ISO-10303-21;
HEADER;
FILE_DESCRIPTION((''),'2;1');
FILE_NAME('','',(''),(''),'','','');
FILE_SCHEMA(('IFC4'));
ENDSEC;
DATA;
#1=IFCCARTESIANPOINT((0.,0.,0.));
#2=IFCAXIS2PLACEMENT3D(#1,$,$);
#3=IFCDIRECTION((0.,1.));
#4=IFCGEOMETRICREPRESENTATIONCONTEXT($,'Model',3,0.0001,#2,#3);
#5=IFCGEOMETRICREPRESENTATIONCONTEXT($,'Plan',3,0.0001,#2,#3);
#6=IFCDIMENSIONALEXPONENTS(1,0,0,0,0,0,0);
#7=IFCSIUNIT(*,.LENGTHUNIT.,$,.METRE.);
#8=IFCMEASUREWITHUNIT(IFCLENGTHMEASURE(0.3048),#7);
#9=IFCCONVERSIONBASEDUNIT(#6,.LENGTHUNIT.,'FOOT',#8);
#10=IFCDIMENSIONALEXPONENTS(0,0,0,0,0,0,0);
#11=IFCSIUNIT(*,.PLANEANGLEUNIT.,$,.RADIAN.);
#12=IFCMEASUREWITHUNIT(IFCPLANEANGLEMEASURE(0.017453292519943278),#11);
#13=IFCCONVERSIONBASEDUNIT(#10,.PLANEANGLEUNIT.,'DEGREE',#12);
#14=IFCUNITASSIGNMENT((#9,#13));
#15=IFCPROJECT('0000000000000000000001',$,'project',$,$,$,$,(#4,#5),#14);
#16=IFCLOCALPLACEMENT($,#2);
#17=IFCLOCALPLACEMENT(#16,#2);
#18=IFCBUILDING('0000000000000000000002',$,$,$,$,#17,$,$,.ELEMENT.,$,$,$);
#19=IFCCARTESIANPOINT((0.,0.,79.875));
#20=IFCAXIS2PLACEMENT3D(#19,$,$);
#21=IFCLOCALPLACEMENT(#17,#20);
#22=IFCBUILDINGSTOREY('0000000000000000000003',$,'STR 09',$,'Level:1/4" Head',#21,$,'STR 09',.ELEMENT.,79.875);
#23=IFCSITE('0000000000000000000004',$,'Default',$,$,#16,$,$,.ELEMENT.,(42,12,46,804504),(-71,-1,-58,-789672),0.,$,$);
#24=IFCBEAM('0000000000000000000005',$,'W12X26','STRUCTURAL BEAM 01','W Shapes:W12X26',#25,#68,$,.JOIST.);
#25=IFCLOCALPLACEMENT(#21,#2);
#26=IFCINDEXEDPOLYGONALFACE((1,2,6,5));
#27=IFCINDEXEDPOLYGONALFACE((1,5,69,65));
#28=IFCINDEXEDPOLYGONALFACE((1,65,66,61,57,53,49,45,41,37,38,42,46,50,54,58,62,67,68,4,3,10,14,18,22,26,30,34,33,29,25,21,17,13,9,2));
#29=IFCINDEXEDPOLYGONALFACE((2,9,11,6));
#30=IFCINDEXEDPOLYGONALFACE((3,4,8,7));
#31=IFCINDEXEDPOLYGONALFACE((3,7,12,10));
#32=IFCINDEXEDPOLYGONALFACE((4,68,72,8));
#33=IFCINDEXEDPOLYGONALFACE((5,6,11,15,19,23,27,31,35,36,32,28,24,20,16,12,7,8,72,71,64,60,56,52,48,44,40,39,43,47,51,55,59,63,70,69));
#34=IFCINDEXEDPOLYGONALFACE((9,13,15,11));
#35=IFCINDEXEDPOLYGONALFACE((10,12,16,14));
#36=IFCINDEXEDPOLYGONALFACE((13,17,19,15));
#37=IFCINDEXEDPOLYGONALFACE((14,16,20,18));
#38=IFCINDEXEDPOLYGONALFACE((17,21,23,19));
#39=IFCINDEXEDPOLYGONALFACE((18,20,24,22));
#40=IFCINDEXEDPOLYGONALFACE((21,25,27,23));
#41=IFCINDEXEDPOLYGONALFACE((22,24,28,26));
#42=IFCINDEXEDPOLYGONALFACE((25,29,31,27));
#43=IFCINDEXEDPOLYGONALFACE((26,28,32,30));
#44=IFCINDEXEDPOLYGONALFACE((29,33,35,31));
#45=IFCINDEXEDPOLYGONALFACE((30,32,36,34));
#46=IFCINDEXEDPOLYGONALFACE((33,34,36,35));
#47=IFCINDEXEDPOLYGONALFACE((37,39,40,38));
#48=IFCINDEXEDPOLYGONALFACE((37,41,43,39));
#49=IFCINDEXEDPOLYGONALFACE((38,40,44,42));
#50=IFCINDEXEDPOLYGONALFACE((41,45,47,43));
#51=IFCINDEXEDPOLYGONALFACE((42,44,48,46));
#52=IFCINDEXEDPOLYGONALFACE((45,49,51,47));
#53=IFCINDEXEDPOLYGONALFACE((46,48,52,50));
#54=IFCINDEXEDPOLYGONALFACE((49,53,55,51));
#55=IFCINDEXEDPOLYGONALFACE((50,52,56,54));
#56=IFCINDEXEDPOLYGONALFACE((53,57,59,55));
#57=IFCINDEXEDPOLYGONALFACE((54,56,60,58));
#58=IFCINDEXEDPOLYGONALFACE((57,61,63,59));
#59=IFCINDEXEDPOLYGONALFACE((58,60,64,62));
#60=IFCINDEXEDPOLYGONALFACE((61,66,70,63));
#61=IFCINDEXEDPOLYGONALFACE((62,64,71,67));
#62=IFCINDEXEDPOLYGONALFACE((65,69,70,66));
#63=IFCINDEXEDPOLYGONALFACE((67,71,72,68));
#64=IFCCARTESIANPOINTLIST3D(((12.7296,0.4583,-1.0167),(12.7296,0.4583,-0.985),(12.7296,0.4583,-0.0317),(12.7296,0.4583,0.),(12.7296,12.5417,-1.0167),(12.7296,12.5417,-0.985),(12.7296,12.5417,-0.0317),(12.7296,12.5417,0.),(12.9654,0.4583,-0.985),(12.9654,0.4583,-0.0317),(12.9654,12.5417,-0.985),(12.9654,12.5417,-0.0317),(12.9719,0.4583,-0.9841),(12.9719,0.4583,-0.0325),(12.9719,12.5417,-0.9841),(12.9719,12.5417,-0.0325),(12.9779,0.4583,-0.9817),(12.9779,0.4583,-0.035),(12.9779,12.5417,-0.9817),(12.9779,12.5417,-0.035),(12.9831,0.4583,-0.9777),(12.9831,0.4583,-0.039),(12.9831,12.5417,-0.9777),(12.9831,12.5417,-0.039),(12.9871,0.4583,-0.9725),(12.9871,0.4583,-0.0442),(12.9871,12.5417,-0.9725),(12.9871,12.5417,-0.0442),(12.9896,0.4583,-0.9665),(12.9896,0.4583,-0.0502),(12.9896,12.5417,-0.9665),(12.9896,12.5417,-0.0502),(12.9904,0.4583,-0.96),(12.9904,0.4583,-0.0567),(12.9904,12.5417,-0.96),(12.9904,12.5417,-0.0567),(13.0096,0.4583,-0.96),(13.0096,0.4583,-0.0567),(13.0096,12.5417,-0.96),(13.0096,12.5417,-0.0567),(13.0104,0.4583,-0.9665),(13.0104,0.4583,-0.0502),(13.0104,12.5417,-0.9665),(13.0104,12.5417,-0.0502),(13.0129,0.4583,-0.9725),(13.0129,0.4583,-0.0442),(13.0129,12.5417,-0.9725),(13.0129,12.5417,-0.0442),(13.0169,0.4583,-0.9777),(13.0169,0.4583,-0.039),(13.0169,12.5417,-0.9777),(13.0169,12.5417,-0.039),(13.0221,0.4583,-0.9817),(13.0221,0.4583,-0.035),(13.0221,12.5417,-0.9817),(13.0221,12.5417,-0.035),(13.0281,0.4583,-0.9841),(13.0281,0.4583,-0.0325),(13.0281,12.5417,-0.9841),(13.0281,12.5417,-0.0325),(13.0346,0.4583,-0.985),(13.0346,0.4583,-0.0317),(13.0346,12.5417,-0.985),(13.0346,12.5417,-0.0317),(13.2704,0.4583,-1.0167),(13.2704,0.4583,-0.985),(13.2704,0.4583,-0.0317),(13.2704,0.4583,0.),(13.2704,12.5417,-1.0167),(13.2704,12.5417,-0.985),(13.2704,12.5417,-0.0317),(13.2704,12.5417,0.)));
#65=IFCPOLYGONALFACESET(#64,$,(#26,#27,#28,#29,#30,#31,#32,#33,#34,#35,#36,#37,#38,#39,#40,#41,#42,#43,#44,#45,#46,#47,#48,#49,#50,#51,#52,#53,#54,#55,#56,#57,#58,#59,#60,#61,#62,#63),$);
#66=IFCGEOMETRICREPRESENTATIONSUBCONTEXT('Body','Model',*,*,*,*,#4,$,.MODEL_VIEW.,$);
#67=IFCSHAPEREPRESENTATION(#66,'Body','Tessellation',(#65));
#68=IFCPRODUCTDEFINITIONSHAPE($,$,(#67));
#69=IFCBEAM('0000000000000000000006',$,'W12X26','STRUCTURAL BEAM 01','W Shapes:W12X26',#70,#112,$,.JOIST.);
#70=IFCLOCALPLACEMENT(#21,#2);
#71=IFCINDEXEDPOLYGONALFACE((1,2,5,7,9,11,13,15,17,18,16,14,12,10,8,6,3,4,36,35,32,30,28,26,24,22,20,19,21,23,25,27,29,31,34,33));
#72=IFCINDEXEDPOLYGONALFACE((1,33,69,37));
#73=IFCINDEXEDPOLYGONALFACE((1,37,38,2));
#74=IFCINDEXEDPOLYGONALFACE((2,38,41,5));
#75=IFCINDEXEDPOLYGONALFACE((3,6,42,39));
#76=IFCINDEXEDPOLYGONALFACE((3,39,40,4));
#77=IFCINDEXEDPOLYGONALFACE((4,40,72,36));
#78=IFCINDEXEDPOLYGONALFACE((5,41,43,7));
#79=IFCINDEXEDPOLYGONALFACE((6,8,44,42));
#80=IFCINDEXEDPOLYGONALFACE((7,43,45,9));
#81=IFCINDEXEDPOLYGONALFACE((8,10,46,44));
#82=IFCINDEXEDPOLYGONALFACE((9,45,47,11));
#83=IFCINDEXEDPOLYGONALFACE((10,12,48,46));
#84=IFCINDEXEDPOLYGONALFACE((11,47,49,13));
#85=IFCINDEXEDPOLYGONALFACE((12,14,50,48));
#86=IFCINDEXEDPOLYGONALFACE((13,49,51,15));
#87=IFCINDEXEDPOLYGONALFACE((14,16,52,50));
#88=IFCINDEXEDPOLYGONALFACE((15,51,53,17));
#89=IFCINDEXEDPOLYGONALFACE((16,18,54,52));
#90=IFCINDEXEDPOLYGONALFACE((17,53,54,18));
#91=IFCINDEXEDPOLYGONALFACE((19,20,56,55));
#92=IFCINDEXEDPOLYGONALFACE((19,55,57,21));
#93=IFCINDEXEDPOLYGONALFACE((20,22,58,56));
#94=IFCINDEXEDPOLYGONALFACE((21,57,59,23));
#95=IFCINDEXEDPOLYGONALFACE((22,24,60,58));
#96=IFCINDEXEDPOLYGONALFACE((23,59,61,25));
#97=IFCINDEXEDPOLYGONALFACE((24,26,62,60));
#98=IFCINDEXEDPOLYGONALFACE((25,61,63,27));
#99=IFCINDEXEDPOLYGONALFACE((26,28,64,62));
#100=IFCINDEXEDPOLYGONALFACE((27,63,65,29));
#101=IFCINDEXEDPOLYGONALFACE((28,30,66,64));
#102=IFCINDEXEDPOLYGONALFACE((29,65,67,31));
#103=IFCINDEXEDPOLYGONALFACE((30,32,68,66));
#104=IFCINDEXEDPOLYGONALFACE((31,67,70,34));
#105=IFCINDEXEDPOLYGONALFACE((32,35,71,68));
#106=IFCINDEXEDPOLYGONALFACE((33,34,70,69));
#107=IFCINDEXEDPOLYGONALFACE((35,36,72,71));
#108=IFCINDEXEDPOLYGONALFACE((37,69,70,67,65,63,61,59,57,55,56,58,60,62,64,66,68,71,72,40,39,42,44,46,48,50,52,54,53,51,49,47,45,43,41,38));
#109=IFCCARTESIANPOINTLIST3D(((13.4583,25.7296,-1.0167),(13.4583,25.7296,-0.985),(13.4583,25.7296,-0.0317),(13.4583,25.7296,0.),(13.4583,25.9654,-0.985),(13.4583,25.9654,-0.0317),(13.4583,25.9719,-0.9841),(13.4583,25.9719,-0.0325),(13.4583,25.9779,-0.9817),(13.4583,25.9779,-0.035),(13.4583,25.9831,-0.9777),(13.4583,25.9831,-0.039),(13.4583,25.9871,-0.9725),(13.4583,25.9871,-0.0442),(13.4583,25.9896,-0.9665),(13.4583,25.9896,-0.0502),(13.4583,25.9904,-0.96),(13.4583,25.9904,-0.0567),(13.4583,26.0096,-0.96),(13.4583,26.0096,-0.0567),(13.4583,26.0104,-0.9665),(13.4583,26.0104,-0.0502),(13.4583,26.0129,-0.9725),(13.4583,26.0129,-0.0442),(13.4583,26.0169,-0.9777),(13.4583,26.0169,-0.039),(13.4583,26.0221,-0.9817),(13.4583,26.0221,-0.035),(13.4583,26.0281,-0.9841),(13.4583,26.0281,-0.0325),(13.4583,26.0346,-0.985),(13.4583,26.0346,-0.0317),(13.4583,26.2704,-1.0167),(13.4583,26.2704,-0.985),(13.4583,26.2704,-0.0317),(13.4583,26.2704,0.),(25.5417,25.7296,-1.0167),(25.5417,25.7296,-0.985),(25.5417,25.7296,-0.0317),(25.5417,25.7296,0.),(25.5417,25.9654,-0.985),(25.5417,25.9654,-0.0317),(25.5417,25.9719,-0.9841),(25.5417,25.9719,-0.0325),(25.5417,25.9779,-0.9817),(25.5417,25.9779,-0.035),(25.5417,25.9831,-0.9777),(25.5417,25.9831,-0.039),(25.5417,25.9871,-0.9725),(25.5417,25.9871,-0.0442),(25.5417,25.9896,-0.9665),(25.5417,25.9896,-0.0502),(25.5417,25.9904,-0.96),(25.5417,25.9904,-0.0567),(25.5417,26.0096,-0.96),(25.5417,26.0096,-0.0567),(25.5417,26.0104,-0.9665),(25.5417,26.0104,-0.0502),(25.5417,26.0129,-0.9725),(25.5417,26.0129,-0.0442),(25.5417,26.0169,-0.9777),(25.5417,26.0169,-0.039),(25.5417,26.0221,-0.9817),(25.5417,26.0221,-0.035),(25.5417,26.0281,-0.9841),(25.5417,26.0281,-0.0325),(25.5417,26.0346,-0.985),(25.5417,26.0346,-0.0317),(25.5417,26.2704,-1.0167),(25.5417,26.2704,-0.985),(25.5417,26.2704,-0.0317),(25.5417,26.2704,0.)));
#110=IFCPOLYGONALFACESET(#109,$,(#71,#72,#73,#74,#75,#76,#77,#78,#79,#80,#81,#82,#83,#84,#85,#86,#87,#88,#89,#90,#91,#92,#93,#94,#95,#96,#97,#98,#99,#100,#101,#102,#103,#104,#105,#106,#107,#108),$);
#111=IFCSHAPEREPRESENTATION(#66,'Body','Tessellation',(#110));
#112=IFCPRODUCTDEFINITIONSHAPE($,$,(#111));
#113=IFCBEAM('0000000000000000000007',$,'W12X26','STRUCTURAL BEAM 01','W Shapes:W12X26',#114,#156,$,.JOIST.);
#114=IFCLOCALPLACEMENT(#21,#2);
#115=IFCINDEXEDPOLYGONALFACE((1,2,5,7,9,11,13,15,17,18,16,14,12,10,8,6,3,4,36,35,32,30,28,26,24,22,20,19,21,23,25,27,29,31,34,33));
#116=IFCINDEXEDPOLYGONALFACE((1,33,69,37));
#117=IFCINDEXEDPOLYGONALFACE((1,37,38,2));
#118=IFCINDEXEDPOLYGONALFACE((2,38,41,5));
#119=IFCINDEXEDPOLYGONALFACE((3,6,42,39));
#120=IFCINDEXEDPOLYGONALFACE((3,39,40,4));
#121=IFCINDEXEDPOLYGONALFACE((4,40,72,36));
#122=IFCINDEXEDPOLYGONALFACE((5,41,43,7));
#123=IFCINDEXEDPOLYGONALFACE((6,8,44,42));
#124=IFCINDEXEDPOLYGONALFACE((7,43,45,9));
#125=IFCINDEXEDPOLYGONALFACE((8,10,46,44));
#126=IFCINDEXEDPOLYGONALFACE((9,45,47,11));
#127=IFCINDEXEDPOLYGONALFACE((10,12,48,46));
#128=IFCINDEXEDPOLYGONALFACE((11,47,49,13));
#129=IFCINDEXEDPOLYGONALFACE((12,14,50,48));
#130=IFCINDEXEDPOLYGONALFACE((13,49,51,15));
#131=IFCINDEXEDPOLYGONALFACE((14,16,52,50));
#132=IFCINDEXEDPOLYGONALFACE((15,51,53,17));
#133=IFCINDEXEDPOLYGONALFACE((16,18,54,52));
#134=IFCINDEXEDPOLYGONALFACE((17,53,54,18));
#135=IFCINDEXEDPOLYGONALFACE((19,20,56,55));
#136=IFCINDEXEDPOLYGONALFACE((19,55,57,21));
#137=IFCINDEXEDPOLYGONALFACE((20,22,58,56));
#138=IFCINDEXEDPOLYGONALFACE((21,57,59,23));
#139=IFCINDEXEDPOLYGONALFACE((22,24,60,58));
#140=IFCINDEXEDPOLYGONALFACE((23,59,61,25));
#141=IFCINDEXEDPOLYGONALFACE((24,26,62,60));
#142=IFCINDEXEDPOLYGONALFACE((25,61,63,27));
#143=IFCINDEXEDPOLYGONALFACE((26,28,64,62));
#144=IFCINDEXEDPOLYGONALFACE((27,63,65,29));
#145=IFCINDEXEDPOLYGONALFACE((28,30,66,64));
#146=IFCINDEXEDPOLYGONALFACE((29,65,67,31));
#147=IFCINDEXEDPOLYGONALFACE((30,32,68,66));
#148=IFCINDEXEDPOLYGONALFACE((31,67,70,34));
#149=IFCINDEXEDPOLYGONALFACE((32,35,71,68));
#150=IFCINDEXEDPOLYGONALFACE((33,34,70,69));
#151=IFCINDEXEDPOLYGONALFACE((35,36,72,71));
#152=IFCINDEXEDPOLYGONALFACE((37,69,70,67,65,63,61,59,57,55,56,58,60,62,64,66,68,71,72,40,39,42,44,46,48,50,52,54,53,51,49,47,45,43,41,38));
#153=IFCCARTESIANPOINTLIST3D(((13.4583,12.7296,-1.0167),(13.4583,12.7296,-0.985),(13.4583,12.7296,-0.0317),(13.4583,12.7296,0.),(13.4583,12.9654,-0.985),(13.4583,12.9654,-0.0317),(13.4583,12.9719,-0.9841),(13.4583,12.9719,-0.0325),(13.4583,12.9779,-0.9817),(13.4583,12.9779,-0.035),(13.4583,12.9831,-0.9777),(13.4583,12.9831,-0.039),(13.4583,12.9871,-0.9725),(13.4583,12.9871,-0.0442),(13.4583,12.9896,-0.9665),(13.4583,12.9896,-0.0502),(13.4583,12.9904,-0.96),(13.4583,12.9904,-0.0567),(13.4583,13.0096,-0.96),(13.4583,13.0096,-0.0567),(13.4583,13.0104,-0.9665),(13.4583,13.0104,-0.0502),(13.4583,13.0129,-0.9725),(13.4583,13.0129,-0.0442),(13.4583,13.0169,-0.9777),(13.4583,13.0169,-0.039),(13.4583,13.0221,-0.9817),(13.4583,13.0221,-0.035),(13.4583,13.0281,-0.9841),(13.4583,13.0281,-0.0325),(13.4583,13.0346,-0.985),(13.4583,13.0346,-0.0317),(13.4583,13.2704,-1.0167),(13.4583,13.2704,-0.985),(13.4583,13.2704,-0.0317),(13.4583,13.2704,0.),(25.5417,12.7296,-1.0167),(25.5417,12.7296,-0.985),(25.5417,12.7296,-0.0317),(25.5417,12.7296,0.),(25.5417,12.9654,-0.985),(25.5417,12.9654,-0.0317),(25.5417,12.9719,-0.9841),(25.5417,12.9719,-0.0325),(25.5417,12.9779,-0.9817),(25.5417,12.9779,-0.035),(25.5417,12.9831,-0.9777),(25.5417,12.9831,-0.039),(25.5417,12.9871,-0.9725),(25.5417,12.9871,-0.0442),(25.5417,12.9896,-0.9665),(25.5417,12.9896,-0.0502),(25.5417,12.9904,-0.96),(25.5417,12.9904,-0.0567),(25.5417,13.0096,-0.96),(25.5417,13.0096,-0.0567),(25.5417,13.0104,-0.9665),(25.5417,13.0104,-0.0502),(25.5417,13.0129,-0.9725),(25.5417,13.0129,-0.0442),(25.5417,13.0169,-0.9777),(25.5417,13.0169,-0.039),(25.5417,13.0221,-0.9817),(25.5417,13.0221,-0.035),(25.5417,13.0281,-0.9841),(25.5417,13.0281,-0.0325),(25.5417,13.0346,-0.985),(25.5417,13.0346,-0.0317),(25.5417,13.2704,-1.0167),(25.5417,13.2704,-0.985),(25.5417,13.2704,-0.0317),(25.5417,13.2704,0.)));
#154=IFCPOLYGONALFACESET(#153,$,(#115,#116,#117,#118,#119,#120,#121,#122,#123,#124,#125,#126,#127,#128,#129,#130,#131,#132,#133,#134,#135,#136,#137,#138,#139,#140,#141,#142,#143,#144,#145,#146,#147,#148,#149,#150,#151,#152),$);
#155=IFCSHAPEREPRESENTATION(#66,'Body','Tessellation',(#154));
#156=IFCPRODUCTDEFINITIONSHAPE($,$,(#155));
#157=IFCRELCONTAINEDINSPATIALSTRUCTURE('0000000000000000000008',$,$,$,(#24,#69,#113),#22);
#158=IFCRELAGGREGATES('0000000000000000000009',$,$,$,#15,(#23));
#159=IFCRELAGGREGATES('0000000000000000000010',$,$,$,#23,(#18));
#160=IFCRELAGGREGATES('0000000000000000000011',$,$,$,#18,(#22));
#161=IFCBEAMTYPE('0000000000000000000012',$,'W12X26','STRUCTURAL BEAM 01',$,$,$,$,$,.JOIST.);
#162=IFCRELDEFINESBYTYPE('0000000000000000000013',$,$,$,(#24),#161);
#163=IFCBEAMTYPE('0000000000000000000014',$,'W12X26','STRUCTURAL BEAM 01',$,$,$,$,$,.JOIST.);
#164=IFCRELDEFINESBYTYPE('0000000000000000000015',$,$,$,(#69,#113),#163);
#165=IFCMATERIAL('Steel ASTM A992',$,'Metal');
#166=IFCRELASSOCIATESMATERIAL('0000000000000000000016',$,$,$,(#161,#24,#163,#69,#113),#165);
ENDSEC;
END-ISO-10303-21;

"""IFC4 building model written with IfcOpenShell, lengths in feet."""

from ifc_helpers import new_model, entity, si_unit, converted_unit, direction, frame, origin, place, context, subcontext, project, spatial, line, arc, indexed_curve, outline, extrude, source, transform, mapped, material, type_object, type_shapes, element, save


model = new_model("IFC4")

# Units and contexts
model_context = context("Model", 3, precision=0.0001, world=origin(), true_north=direction((0.0, 1.0)))
plan_context = context("Plan", 3, precision=0.0001, world=origin(), true_north=direction((0.0, 1.0)))
body_context = subcontext(model_context, "Body", "Model", "MODEL_VIEW")
ifc_project = project(units=[converted_unit("LENGTHUNIT", "FOOT", entity("IfcLengthMeasure", 0.3048), si_unit("LENGTHUNIT", "METRE"), dimensions=[1, 0, 0, 0, 0, 0, 0]), converted_unit("PLANEANGLEUNIT", "DEGREE", entity("IfcPlaneAngleMeasure", 0.017453292519943278), si_unit("PLANEANGLEUNIT", "RADIAN"), dimensions=[0, 0, 0, 0, 0, 0, 0])], contexts=[model_context, plan_context])

# Site, building, storey
site_placement = place(None, origin())
site = spatial("IfcSite", under=ifc_project, at=site_placement, Name="Default", CompositionType="ELEMENT", RefLatitude=(42, 12, 46, 804504), RefLongitude=(-71, -1, -58, -789672), RefElevation=0.0)
building_placement = place(site_placement, origin())
building = spatial("IfcBuilding", under=site, at=building_placement, CompositionType="ELEMENT")
storey_placement = place(building_placement, frame((0.0, 0.0, 79.875)))
storey = spatial("IfcBuildingStorey", under=building, at=storey_placement, Name="STR 09", ObjectType="Level:1/4\" Head", LongName="STR 09", CompositionType="ELEMENT", Elevation=79.875)

# Beams
ifc_material = material(Name="Steel ASTM A992", Category="Metal")
beam_type_1 = type_object("IfcBeamType", Name="W12X26", Description="STRUCTURAL BEAM 01", PredefinedType="JOIST", material=ifc_material)
shared_shape_1 = source(origin(), body_context, "Body", "SweptSolid", [
    extrude(outline(indexed_curve([(-0.2704, -0.4767), (-0.2704, -0.5083), (0.2704, -0.5083), (0.2704, -0.4767), (0.0346, -0.4767), (0.0169, -0.4693), (0.0096, -0.4517), (0.0096, 0.4517), (0.0169, 0.4693), (0.0346, 0.4767), (0.2704, 0.4767), (0.2704, 0.5083), (-0.2704, 0.5083), (-0.2704, 0.4767), (-0.0346, 0.4767), (-0.0169, 0.4693), (-0.0096, 0.4517), (-0.0096, -0.4517), (-0.0169, -0.4693), (-0.0346, -0.4767)], segments=[line(1, 2, 3, 4, 5), arc(5, 6, 7), line(7, 8), arc(8, 9, 10), line(10, 11, 12, 13, 14, 15), arc(15, 16, 17), line(17, 18), arc(18, 19, 20), line(20, 1)], self_intersect=False)), frame((-6.1033, 0.0, 0.0), z_axis=(-1.0, 0.0, 0.0), x_axis=(0.0, -1.0, 0.0)), (0.0, 0.0, -1.0), 12.0833),
])
type_shapes(beam_type_1, [shared_shape_1])
for number, where, z_axis, x_axis, name in (
    (1, (13.0, 6.5617, -0.5083), (0.0, 0.0, 1.0), (0.0, 1.0, 0.0), "W12X26"),
):
    element("IfcBeam", number, at=place(storey_placement, frame(where, z_axis=z_axis, x_axis=x_axis)), inside=storey, type_object=beam_type_1, material=ifc_material, Name=name, Description="STRUCTURAL BEAM 01", ObjectType="W Shapes:W12X26", PredefinedType="JOIST", context=body_context, shape_type="MappedRepresentation", body=[
        mapped(shared_shape_1, transform((0.0, 0.0, 0.0), scale=1.0)),
    ])
beam_type_2 = type_object("IfcBeamType", Name="W12X26", Description="STRUCTURAL BEAM 01", PredefinedType="JOIST", material=ifc_material)
shared_shape_2 = source(origin(), body_context, "Body", "SweptSolid", [
    extrude(outline(indexed_curve([(-0.2704, -0.4767), (-0.2704, -0.5083), (0.2704, -0.5083), (0.2704, -0.4767), (0.0346, -0.4767), (0.0169, -0.4693), (0.0096, -0.4517), (0.0096, 0.4517), (0.0169, 0.4693), (0.0346, 0.4767), (0.2704, 0.4767), (0.2704, 0.5083), (-0.2704, 0.5083), (-0.2704, 0.4767), (-0.0346, 0.4767), (-0.0169, 0.4693), (-0.0096, 0.4517), (-0.0096, -0.4517), (-0.0169, -0.4693), (-0.0346, -0.4767)], segments=[line(1, 2, 3, 4, 5), arc(5, 6, 7), line(7, 8), arc(8, 9, 10), line(10, 11, 12, 13, 14, 15), arc(15, 16, 17), line(17, 18), arc(18, 19, 20), line(20, 1)], self_intersect=False)), frame((-6.2267, 0.0, 0.0), z_axis=(-1.0, 0.0, 0.0), x_axis=(0.0, -1.0, 0.0)), (0.0, 0.0, -1.0), 12.0833),
])
type_shapes(beam_type_2, [shared_shape_2])
for number, where, name in (
    (2, (19.685, 26.0, -0.5083), "W12X26"),
    (3, (19.685, 13.0, -0.5083), "W12X26"),
):
    element("IfcBeam", number, at=place(storey_placement, frame(where)), inside=storey, type_object=beam_type_2, material=ifc_material, Name=name, Description="STRUCTURAL BEAM 01", ObjectType="W Shapes:W12X26", PredefinedType="JOIST", context=body_context, shape_type="MappedRepresentation", body=[
        mapped(shared_shape_2, transform((0.0, 0.0, 0.0), scale=1.0)),
    ])

save(model, "model.ifc")
